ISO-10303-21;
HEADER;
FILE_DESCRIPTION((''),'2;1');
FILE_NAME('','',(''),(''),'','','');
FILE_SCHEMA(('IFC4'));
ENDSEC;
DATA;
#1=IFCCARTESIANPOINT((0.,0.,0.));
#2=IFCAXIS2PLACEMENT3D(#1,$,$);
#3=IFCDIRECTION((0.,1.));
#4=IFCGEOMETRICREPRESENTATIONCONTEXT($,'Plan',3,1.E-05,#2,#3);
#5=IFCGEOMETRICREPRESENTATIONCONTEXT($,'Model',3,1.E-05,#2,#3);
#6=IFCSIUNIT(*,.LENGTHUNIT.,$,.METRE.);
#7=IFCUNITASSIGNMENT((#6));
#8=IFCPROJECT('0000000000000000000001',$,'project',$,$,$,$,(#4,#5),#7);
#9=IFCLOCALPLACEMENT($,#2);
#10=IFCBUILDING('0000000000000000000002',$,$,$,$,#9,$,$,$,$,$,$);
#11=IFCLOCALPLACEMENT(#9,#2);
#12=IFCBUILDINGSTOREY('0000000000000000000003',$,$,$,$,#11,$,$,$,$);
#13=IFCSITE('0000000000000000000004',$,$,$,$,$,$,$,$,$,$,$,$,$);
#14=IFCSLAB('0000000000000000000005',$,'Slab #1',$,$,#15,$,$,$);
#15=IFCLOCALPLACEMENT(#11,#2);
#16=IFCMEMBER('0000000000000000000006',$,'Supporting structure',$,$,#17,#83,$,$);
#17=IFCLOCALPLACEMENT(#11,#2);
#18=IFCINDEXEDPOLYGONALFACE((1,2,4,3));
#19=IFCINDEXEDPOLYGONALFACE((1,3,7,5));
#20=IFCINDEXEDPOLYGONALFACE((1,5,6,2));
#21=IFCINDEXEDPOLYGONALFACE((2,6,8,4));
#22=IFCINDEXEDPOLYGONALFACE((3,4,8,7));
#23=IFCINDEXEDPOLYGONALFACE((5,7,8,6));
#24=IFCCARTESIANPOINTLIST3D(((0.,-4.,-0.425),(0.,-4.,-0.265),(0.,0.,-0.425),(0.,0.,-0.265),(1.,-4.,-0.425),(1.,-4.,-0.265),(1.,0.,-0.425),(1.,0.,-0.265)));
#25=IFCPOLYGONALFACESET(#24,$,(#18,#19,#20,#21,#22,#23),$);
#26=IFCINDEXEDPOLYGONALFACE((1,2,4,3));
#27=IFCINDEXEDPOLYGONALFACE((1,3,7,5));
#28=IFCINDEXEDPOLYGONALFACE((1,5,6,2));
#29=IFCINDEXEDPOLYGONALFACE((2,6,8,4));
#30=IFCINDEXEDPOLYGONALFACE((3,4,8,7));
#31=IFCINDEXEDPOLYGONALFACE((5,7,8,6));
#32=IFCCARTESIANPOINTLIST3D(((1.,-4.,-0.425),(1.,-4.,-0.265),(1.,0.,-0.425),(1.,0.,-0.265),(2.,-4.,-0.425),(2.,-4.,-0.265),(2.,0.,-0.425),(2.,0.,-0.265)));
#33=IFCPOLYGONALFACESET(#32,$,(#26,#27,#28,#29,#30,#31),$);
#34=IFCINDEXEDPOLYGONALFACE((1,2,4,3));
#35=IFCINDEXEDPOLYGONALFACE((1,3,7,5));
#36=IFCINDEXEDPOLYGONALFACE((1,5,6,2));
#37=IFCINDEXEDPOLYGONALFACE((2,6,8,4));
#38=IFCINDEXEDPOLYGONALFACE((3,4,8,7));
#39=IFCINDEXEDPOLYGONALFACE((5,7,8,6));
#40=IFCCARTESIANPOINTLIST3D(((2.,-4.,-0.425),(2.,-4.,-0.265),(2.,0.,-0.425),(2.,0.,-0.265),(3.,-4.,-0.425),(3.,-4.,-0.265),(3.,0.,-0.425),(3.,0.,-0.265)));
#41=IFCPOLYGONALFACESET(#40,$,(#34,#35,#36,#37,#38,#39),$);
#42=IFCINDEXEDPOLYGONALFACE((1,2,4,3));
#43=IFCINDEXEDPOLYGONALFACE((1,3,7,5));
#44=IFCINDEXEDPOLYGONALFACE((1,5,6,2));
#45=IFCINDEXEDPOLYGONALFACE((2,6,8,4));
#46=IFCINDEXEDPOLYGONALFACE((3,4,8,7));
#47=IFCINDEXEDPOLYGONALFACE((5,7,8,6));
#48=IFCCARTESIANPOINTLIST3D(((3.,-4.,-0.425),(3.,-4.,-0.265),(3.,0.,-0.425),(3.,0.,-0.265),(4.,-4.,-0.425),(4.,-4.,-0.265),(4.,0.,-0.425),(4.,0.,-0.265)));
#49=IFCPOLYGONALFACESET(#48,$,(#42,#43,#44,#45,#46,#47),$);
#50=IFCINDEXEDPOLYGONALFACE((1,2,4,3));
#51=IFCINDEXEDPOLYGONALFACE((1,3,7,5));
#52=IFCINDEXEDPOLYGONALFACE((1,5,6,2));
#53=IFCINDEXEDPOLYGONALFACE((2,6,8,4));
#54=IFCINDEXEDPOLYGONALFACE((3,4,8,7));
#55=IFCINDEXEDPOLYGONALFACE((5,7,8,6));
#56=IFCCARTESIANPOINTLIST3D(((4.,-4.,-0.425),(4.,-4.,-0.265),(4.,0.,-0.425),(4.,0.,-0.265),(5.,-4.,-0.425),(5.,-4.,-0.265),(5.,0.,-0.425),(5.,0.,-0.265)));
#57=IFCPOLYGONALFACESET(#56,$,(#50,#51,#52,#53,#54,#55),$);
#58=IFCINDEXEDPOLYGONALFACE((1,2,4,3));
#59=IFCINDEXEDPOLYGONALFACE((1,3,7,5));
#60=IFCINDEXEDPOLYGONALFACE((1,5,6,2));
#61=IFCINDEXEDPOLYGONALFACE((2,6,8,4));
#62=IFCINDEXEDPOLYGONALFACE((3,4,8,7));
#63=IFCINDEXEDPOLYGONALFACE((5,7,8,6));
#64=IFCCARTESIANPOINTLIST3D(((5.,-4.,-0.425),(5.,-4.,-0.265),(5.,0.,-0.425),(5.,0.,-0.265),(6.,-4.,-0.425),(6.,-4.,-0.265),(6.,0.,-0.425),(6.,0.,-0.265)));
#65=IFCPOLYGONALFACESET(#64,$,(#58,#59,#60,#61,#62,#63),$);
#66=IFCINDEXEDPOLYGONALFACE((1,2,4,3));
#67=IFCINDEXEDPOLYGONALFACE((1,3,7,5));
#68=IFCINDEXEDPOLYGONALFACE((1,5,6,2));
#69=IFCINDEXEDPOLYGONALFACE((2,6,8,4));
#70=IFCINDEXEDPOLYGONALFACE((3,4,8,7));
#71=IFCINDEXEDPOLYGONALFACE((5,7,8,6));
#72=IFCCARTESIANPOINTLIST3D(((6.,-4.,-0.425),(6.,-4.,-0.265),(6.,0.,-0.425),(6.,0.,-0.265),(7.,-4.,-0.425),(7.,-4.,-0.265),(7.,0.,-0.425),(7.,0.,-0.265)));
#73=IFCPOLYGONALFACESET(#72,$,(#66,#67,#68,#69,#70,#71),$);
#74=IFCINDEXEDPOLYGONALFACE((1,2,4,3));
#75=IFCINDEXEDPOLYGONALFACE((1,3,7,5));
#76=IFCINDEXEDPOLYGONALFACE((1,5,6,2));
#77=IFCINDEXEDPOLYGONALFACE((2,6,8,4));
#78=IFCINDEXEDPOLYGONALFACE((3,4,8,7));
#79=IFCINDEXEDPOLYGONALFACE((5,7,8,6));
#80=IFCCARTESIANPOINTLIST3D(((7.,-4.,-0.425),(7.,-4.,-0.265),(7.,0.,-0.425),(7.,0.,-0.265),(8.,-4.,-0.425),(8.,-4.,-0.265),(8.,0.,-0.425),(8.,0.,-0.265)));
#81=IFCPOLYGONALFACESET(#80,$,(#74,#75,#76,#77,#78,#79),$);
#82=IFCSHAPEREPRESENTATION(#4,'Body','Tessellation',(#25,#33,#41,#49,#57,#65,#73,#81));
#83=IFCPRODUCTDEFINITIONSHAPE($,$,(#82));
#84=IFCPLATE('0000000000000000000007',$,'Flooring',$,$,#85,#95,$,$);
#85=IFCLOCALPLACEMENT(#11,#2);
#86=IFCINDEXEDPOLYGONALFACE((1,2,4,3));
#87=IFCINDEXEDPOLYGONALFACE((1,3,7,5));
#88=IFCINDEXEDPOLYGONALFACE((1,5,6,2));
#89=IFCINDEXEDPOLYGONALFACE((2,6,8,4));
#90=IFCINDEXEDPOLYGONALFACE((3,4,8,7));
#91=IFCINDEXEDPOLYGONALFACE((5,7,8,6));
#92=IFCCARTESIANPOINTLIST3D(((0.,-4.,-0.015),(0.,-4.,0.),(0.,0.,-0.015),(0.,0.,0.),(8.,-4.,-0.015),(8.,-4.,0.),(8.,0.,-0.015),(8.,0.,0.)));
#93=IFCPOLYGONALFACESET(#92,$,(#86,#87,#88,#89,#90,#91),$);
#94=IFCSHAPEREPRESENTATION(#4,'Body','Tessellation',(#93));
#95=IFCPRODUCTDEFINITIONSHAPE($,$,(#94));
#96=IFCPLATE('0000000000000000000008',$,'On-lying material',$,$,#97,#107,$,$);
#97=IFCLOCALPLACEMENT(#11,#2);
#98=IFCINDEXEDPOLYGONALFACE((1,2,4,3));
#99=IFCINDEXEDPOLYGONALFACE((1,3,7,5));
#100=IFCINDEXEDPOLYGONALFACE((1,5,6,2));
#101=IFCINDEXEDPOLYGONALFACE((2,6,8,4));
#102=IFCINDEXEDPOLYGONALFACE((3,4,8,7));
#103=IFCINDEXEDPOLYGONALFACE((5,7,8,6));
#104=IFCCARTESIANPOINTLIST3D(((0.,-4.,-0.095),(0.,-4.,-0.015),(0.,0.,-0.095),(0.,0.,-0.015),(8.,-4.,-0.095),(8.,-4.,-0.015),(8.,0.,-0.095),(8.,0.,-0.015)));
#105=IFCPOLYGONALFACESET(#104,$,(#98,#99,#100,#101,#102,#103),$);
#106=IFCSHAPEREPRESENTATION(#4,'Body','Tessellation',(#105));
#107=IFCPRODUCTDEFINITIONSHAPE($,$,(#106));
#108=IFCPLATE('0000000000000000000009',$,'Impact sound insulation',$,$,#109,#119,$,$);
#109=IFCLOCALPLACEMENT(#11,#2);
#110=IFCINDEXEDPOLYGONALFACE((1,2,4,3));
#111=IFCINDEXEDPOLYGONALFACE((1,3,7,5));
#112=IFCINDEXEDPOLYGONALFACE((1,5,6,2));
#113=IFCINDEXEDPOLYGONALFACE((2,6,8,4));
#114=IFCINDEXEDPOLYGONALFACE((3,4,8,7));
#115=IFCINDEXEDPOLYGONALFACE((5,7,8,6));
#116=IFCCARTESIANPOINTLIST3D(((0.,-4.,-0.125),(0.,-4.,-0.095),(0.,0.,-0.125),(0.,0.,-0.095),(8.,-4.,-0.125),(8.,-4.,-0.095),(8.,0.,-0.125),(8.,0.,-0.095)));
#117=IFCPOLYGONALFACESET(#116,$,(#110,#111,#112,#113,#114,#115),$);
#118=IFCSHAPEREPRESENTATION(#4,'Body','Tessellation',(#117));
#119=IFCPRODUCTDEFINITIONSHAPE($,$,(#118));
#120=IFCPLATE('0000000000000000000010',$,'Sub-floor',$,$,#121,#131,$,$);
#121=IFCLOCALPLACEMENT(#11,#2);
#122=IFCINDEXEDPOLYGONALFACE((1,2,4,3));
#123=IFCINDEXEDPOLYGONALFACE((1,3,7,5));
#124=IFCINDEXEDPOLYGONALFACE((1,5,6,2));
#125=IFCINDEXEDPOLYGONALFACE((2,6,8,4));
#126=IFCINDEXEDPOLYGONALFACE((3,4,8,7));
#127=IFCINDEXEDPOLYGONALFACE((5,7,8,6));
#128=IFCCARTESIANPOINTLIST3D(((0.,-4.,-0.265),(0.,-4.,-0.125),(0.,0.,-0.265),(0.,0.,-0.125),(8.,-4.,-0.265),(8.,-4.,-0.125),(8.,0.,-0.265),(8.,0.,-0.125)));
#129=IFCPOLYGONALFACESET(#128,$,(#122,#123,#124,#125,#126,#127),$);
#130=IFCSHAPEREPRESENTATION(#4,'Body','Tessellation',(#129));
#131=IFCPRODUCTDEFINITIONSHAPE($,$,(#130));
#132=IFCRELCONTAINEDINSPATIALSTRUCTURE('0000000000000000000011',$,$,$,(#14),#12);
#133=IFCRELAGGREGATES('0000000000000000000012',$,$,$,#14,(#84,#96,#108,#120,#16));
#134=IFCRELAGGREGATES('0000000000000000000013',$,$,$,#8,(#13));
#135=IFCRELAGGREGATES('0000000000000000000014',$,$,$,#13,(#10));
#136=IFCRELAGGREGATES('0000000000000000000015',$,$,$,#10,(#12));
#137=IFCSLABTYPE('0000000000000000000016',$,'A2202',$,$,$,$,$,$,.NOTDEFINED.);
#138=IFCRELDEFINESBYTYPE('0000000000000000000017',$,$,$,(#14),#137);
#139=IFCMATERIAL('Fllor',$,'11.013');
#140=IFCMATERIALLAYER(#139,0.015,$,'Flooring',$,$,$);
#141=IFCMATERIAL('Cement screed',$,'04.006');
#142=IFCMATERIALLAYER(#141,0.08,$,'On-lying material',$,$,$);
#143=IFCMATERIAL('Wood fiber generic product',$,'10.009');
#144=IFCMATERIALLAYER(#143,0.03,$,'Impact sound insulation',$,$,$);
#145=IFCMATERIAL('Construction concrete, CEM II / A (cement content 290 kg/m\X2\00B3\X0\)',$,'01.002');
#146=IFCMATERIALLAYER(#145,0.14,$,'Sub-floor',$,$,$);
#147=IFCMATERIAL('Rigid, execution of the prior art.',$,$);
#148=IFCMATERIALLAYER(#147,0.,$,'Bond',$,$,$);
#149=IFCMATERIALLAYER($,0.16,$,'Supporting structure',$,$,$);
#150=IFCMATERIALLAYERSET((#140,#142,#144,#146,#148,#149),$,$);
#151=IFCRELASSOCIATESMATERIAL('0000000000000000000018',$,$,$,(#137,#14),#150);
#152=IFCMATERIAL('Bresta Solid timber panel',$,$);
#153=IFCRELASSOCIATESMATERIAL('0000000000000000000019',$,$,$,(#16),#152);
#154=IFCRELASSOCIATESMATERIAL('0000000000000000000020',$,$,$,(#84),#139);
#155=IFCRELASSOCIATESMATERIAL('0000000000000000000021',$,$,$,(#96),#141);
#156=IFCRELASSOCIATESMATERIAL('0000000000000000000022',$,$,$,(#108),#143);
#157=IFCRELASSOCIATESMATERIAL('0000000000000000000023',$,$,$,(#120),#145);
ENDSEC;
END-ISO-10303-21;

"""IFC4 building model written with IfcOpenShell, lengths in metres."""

from ifc_helpers import new_model, si_unit, direction, frame, frame_2d, origin, origin_with_axes, place, context, project, spatial, rectangle, extrude, material, layer, layer_set, type_object, element, aggregate, save


model = new_model("IFC4")

# Units and contexts
plan_context = context("Plan", 3, precision=1e-05, world=origin(), true_north=direction((0.0, 1.0)))
model_context = context("Model", 3, precision=1e-05, world=origin(), true_north=direction((0.0, 1.0)))
ifc_project = project(units=[si_unit("LENGTHUNIT", "METRE")], contexts=[plan_context, model_context])

# Site, building, storey
site = spatial("IfcSite", under=ifc_project)
building_placement = place(None, origin())
building = spatial("IfcBuilding", under=site, at=building_placement)
storey_placement = place(building_placement, origin())
storey = spatial("IfcBuildingStorey", under=building, at=storey_placement)

# Slab, member, plates
ifc_material_1 = material(Name="Fllor", Category="11.013")
ifc_layer_1 = layer(ifc_material_1, 0.015, Name="Flooring")
ifc_material_2 = material(Name="Cement screed", Category="04.006")
ifc_layer_2 = layer(ifc_material_2, 0.08, Name="On-lying material")
ifc_material_3 = material(Name="Wood fiber generic product", Category="10.009")
ifc_layer_3 = layer(ifc_material_3, 0.03, Name="Impact sound insulation")
ifc_material_4 = material(Name="Construction concrete, CEM II / A (cement content 290 kg/m³)", Category="01.002")
ifc_layer_4 = layer(ifc_material_4, 0.14, Name="Sub-floor")
ifc_material_5 = material(Name="Rigid, execution of the prior art.")
ifc_layer_5 = layer(ifc_material_5, 0.0, Name="Bond")
ifc_layer_6 = layer(None, 0.16, Name="Supporting structure")
ifc_layer_set = layer_set([ifc_layer_1, ifc_layer_2, ifc_layer_3, ifc_layer_4, ifc_layer_5, ifc_layer_6])
slab_type = type_object("IfcSlabType", Name="A2202", PredefinedType="NOTDEFINED", material=ifc_layer_set)
slab_placement = place(None, frame((0.0, 0.0, 0.0), z_axis=(0.0, 0.0, -1.0), x_axis=(1.0, 0.0, 0.0)))
slab = element("IfcSlab", 1, at=slab_placement, inside=storey, type_object=slab_type, material=ifc_layer_set, Name="Slab #1")
ifc_material_6 = material(Name="Bresta Solid timber panel")
member_placement = place(slab_placement, origin())
member = element("IfcMember", 2, at=member_placement, material=ifc_material_6, Name="Supporting structure", context=plan_context, shape_type="SweptSolid", body=[
    extrude(rectangle(XDim=1.0, YDim=0.16, at=frame_2d((0.5, 0.08), x_axis=(1.0, 0.0))), frame((0.0, 4.0, 0.265), z_axis=(0.0, -1.0, 0.0), x_axis=(1.0, 0.0, 0.0)), (0.0, 0.0, 1.0), 4.0),
    extrude(rectangle(XDim=1.0, YDim=0.16, at=frame_2d((0.5, 0.08), x_axis=(1.0, 0.0))), frame((1.0, 4.0, 0.265), z_axis=(0.0, -1.0, 0.0), x_axis=(1.0, 0.0, 0.0)), (0.0, 0.0, 1.0), 4.0),
    extrude(rectangle(XDim=1.0, YDim=0.16, at=frame_2d((0.5, 0.08), x_axis=(1.0, 0.0))), frame((2.0, 4.0, 0.265), z_axis=(0.0, -1.0, 0.0), x_axis=(1.0, 0.0, 0.0)), (0.0, 0.0, 1.0), 4.0),
    extrude(rectangle(XDim=1.0, YDim=0.16, at=frame_2d((0.5, 0.08), x_axis=(1.0, 0.0))), frame((3.0, 4.0, 0.265), z_axis=(0.0, -1.0, 0.0), x_axis=(1.0, 0.0, 0.0)), (0.0, 0.0, 1.0), 4.0),
    extrude(rectangle(XDim=1.0, YDim=0.16, at=frame_2d((0.5, 0.08), x_axis=(1.0, 0.0))), frame((4.0, 4.0, 0.265), z_axis=(0.0, -1.0, 0.0), x_axis=(1.0, 0.0, 0.0)), (0.0, 0.0, 1.0), 4.0),
    extrude(rectangle(XDim=1.0, YDim=0.16, at=frame_2d((0.5, 0.08), x_axis=(1.0, 0.0))), frame((5.0, 4.0, 0.265), z_axis=(0.0, -1.0, 0.0), x_axis=(1.0, 0.0, 0.0)), (0.0, 0.0, 1.0), 4.0),
    extrude(rectangle(XDim=1.0, YDim=0.16, at=frame_2d((0.5, 0.08), x_axis=(1.0, 0.0))), frame((6.0, 4.0, 0.265), z_axis=(0.0, -1.0, 0.0), x_axis=(1.0, 0.0, 0.0)), (0.0, 0.0, 1.0), 4.0),
    extrude(rectangle(XDim=1.0, YDim=0.16, at=frame_2d((0.5, 0.08), x_axis=(1.0, 0.0))), frame((7.0, 4.0, 0.265), z_axis=(0.0, -1.0, 0.0), x_axis=(1.0, 0.0, 0.0)), (0.0, 0.0, 1.0), 4.0),
])
plate_1_placement = place(slab_placement, origin())
plate_1 = element("IfcPlate", 3, at=plate_1_placement, material=ifc_material_1, Name="Flooring", context=plan_context, shape_type="SweptSolid", body=[
    extrude(rectangle(XDim=8.0, YDim=4.0, at=frame_2d((4.0, 2.0), x_axis=(1.0, 0.0))), origin_with_axes(), (0.0, 0.0, 1.0), 0.015),
])
plate_2_placement = place(slab_placement, origin())
plate_2 = element("IfcPlate", 4, at=plate_2_placement, material=ifc_material_2, Name="On-lying material", context=plan_context, shape_type="SweptSolid", body=[
    extrude(rectangle(XDim=8.0, YDim=4.0, at=frame_2d((4.0, 2.0), x_axis=(1.0, 0.0))), frame((0.0, 0.0, 0.015), z_axis=(0.0, 0.0, 1.0), x_axis=(1.0, 0.0, 0.0)), (0.0, 0.0, 1.0), 0.08),
])
plate_3_placement = place(slab_placement, origin())
plate_3 = element("IfcPlate", 5, at=plate_3_placement, material=ifc_material_3, Name="Impact sound insulation", context=plan_context, shape_type="SweptSolid", body=[
    extrude(rectangle(XDim=8.0, YDim=4.0, at=frame_2d((4.0, 2.0), x_axis=(1.0, 0.0))), frame((0.0, 0.0, 0.095), z_axis=(0.0, 0.0, 1.0), x_axis=(1.0, 0.0, 0.0)), (0.0, 0.0, 1.0), 0.03),
])
plate_4_placement = place(slab_placement, origin())
plate_4 = element("IfcPlate", 6, at=plate_4_placement, material=ifc_material_4, Name="Sub-floor", context=plan_context, shape_type="SweptSolid", body=[
    extrude(rectangle(XDim=8.0, YDim=4.0, at=frame_2d((4.0, 2.0), x_axis=(1.0, 0.0))), frame((0.0, 0.0, 0.125), z_axis=(0.0, 0.0, 1.0), x_axis=(1.0, 0.0, 0.0)), (0.0, 0.0, 1.0), 0.14),
])
aggregate(slab, [plate_1, plate_2, plate_3, plate_4, member])

save(model, "model.ifc")
